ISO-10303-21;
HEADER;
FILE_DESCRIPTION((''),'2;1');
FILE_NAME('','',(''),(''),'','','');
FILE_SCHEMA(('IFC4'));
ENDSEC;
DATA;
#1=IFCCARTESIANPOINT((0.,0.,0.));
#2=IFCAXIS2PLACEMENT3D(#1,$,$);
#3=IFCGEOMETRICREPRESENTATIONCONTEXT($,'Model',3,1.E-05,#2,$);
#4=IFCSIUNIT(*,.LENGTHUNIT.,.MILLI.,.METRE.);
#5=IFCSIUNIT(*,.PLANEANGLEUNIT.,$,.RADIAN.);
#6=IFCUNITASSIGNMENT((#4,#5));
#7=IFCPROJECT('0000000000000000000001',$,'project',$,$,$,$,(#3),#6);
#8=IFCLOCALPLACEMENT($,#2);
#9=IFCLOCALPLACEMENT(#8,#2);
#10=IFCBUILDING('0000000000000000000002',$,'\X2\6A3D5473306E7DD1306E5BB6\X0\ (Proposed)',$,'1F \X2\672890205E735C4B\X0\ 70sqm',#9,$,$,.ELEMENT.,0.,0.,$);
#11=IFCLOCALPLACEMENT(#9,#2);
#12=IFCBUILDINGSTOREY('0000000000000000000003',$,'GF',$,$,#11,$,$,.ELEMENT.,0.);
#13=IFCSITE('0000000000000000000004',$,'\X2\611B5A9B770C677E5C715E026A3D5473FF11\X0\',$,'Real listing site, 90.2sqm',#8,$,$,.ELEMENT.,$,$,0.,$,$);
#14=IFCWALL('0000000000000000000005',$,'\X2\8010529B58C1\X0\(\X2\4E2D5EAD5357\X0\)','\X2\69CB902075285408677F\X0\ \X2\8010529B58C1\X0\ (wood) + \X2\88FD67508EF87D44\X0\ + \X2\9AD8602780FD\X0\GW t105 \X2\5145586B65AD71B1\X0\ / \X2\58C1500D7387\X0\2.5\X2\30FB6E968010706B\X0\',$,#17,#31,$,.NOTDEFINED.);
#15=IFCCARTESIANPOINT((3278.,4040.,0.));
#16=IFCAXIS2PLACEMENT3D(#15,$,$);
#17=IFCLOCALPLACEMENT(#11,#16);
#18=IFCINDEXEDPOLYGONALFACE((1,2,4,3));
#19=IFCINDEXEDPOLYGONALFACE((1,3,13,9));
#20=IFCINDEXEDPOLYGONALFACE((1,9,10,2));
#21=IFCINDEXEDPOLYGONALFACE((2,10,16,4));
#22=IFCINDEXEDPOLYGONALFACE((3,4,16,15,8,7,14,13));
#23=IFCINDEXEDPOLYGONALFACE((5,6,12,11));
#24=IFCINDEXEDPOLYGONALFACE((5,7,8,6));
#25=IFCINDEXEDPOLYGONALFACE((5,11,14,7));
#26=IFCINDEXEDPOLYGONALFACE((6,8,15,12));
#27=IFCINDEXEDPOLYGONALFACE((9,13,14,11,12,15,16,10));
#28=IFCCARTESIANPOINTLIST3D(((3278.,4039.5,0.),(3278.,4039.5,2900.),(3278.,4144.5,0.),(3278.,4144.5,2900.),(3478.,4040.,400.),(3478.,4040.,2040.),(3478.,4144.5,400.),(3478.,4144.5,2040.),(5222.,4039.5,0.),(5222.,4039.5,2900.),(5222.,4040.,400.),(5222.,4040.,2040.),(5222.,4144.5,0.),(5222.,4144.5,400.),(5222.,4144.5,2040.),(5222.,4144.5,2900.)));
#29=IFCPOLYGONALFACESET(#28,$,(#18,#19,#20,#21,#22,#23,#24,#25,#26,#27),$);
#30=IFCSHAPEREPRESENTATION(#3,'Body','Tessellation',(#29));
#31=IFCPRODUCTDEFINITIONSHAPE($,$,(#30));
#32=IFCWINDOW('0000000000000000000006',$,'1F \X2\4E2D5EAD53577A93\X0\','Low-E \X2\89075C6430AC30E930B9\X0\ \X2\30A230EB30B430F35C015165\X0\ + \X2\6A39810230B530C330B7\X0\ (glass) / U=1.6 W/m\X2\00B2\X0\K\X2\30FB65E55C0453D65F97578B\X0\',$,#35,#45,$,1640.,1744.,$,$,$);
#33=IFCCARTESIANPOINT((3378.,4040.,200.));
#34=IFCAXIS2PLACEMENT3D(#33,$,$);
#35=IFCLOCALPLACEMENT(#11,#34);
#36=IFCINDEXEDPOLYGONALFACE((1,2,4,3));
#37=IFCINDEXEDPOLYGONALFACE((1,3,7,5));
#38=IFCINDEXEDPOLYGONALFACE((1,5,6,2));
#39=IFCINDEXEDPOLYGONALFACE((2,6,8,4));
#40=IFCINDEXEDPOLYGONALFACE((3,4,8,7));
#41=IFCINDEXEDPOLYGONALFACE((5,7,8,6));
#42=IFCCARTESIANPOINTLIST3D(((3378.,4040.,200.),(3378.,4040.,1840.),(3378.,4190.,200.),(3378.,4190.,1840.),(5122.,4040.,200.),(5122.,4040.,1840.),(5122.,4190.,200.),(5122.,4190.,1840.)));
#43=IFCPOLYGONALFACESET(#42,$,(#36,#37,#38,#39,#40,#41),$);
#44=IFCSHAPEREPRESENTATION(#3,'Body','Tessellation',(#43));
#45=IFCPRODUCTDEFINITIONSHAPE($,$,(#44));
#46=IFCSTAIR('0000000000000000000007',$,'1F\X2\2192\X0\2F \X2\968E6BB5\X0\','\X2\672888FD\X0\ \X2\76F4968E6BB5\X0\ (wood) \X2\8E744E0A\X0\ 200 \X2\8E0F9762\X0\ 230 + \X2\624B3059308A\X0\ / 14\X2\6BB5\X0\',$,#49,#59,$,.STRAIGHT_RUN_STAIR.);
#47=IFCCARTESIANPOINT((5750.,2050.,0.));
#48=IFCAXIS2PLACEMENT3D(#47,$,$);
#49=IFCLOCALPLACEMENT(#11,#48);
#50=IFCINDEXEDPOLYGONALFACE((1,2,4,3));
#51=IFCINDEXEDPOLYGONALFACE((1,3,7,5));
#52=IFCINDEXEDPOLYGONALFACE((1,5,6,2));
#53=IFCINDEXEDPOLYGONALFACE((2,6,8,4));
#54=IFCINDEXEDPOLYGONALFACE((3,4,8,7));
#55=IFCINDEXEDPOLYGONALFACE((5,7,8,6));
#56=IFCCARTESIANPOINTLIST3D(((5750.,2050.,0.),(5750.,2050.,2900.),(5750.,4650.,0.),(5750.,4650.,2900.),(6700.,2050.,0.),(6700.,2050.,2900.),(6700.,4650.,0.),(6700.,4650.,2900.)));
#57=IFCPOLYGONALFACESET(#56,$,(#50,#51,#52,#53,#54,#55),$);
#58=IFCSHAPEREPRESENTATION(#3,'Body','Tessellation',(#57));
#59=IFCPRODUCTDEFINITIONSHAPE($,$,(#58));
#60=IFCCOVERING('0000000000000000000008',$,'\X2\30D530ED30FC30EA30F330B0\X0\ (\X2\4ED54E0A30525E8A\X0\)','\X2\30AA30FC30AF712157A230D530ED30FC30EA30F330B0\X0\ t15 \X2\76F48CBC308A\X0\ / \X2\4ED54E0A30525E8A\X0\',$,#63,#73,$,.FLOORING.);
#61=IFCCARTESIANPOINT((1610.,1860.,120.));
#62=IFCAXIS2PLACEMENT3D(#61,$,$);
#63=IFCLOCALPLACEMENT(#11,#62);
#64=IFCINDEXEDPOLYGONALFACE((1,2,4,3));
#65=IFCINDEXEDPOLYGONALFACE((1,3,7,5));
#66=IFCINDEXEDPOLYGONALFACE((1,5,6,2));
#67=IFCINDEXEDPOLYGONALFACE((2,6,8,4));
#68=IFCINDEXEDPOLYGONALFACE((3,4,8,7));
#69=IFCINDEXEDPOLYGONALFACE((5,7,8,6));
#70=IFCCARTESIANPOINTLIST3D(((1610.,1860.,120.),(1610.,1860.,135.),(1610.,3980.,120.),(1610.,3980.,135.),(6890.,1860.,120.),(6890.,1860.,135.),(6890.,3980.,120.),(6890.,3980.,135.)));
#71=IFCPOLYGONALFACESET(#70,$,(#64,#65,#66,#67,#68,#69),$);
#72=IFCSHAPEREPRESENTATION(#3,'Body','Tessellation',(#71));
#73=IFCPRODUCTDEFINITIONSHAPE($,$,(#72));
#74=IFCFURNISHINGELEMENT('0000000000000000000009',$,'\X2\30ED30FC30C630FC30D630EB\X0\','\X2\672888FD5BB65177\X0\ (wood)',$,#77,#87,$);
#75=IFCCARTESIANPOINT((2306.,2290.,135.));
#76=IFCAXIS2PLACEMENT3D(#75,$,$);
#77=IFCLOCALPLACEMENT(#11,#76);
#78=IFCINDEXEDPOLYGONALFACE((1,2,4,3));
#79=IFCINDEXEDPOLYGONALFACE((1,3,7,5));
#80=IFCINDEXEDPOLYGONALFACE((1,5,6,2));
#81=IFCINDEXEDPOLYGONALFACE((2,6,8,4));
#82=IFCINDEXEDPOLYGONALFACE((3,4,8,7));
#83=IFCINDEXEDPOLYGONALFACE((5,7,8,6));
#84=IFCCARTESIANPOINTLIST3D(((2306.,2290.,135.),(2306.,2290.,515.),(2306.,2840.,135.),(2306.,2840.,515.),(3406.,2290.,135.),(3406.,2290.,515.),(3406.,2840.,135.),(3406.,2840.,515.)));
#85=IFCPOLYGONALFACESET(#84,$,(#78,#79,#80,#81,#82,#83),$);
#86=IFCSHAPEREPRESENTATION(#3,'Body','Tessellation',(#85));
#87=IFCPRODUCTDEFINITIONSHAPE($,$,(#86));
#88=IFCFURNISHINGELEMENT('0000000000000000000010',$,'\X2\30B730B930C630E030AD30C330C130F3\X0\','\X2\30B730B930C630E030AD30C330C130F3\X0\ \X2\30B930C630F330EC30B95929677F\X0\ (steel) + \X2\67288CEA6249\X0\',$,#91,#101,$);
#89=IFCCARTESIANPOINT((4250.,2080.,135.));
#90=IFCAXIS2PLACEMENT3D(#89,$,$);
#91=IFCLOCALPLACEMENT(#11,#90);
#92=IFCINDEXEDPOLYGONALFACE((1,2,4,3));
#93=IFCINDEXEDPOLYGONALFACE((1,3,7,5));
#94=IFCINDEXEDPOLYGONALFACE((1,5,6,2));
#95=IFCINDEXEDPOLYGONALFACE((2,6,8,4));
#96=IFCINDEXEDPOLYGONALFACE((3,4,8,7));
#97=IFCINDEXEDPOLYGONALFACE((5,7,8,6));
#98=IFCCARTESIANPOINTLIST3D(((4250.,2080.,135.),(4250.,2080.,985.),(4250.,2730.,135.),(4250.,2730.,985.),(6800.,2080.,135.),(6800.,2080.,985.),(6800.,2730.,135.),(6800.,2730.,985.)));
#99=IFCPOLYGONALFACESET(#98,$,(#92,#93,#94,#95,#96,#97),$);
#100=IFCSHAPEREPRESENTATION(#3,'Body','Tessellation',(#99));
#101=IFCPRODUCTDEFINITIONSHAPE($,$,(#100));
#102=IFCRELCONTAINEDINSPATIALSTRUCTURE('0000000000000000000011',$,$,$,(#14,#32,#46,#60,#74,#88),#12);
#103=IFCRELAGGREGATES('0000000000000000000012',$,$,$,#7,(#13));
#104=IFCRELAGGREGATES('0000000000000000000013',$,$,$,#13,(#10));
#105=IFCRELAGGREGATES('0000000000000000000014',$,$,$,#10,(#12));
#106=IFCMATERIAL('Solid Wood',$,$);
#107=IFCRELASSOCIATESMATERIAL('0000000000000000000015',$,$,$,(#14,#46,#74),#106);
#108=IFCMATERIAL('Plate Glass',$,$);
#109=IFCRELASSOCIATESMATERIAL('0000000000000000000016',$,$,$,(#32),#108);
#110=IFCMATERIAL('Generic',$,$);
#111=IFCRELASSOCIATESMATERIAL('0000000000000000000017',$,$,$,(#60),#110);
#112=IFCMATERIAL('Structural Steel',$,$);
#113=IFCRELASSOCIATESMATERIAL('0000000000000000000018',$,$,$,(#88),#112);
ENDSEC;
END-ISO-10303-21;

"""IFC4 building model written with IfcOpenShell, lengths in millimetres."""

from ifc_helpers import new_model, si_unit, frame, frame_2d, origin, place, context, project, spatial, rectangle, extrude, material, element, fill, save


model = new_model("IFC4")

# Units and contexts
model_context = context("Model", 3, precision=1e-05, world=origin())
ifc_project = project(units=[si_unit("LENGTHUNIT", "METRE", prefix="MILLI"), si_unit("PLANEANGLEUNIT", "RADIAN")], contexts=[model_context])

# Site, building, storey
site_placement = place(None, origin())
site = spatial("IfcSite", under=ifc_project, at=site_placement, Name="愛媛県松山市樽味１", ObjectType="Real listing site, 90.2sqm", CompositionType="ELEMENT", RefElevation=0.0)
building_placement = place(site_placement, origin())
building = spatial("IfcBuilding", under=site, at=building_placement, Name="樽味の緑の家 (Proposed)", ObjectType="1F 木造平屋 70sqm", CompositionType="ELEMENT", ElevationOfRefHeight=0.0, ElevationOfTerrain=0.0)
storey_placement = place(building_placement, origin())
storey = spatial("IfcBuildingStorey", under=building, at=storey_placement, Name="GF", CompositionType="ELEMENT", Elevation=0.0)

# Shared definitions
ifc_material_1 = material(Name="Solid Wood")

# Shared definitions
ifc_material_2 = material(Name="Plate Glass")

# Wall, opening, window
wall_1_placement = place(storey_placement, frame((3278.0, 4040.0, 0.0)))
wall_1 = element("IfcWall", 1, at=wall_1_placement, inside=storey, material=ifc_material_1, Name="耐力壁(中庭南)", Description="構造用合板 耐力壁 (wood) + 製材軸組 + 高性能GW t105 充填断熱 / 壁倍率2.5・準耐火", PredefinedType="NOTDEFINED", context=model_context, shape_type="SweptSolid", body=[
    extrude(rectangle(XDim=1944.0, YDim=105.0, at=frame_2d((972.0, 52.0))), frame((3278.0, 4040.0, 0.0)), (0.0, 0.0, 1.0), 2900.0),
])
opening_1_placement = place(storey_placement, frame((3378.0, 4040.0, 200.0)))
opening_1 = element("IfcOpeningElement", 2, at=opening_1_placement, cuts=wall_1, PredefinedType="NOTDEFINED", context=model_context, shape_type="SweptSolid", body=[
    extrude(rectangle(XDim=1744.0, YDim=150.0, at=frame_2d((872.0, 75.0))), frame((3378.0, 4040.0, 200.0)), (0.0, 0.0, 1.0), 1640.0),
])
window_1_placement = place(storey_placement, frame((3378.0, 4040.0, 200.0)))
window_1 = element("IfcWindow", 3, at=window_1_placement, inside=storey, material=ifc_material_2, Name="1F 中庭南窓", Description="Low-E 複層ガラス アルゴン封入 + 樹脂サッシ (glass) / U=1.6 W/m²K・日射取得型", OverallHeight=1640.0, OverallWidth=1744.0, context=model_context, shape_type="SweptSolid", body=[
    extrude(rectangle(XDim=1744.0, YDim=150.0, at=frame_2d((872.0, 75.0))), frame((3378.0, 4040.0, 200.0)), (0.0, 0.0, 1.0), 1640.0),
])
fill(opening_1, window_1)

# Stair
stair_placement = place(storey_placement, frame((5750.0, 2050.0, 0.0)))
element("IfcStair", 4, at=stair_placement, inside=storey, material=ifc_material_1, Name="1F→2F 階段", Description="木製 直階段 (wood) 蹴上 200 踏面 230 + 手すり / 14段", PredefinedType="STRAIGHT_RUN_STAIR", context=model_context, shape_type="SweptSolid", body=[
    extrude(rectangle(XDim=950.0, YDim=2600.0, at=frame_2d((475.0, 1300.0))), frame((5750.0, 2050.0, 0.0)), (0.0, 0.0, 1.0), 2900.0),
])

# Covering
ifc_material_3 = material(Name="Generic")
covering_placement = place(storey_placement, frame((1610.0, 1860.0, 120.0)))
element("IfcCovering", 5, at=covering_placement, inside=storey, material=ifc_material_3, Name="フローリング (仕上げ床)", Description="オーク無垢フローリング t15 直貼り / 仕上げ床", PredefinedType="FLOORING", context=model_context, shape_type="SweptSolid", body=[
    extrude(rectangle(XDim=5280.0, YDim=2120.0, at=frame_2d((2640.0, 1060.0))), frame((1610.0, 1860.0, 120.0)), (0.0, 0.0, 1.0), 15.0),
])

# Furnishing elements
furnishing_1_placement = place(storey_placement, frame((2306.0, 2290.0, 135.0)))
element("IfcFurnishingElement", 6, at=furnishing_1_placement, inside=storey, material=ifc_material_1, Name="ローテーブル", Description="木製家具 (wood)", context=model_context, shape_type="SweptSolid", body=[
    extrude(rectangle(XDim=1100.0, YDim=550.0, at=frame_2d((550.0, 275.0))), frame((2306.0, 2290.0, 135.0)), (0.0, 0.0, 1.0), 380.0),
])
ifc_material_4 = material(Name="Structural Steel")
furnishing_2_placement = place(storey_placement, frame((4250.0, 2080.0, 135.0)))
element("IfcFurnishingElement", 7, at=furnishing_2_placement, inside=storey, material=ifc_material_4, Name="システムキッチン", Description="システムキッチン ステンレス天板 (steel) + 木質扉", context=model_context, shape_type="SweptSolid", body=[
    extrude(rectangle(XDim=2550.0, YDim=650.0, at=frame_2d((1275.0, 325.0))), frame((4250.0, 2080.0, 135.0)), (0.0, 0.0, 1.0), 850.0),
])

save(model, "model.ifc")
